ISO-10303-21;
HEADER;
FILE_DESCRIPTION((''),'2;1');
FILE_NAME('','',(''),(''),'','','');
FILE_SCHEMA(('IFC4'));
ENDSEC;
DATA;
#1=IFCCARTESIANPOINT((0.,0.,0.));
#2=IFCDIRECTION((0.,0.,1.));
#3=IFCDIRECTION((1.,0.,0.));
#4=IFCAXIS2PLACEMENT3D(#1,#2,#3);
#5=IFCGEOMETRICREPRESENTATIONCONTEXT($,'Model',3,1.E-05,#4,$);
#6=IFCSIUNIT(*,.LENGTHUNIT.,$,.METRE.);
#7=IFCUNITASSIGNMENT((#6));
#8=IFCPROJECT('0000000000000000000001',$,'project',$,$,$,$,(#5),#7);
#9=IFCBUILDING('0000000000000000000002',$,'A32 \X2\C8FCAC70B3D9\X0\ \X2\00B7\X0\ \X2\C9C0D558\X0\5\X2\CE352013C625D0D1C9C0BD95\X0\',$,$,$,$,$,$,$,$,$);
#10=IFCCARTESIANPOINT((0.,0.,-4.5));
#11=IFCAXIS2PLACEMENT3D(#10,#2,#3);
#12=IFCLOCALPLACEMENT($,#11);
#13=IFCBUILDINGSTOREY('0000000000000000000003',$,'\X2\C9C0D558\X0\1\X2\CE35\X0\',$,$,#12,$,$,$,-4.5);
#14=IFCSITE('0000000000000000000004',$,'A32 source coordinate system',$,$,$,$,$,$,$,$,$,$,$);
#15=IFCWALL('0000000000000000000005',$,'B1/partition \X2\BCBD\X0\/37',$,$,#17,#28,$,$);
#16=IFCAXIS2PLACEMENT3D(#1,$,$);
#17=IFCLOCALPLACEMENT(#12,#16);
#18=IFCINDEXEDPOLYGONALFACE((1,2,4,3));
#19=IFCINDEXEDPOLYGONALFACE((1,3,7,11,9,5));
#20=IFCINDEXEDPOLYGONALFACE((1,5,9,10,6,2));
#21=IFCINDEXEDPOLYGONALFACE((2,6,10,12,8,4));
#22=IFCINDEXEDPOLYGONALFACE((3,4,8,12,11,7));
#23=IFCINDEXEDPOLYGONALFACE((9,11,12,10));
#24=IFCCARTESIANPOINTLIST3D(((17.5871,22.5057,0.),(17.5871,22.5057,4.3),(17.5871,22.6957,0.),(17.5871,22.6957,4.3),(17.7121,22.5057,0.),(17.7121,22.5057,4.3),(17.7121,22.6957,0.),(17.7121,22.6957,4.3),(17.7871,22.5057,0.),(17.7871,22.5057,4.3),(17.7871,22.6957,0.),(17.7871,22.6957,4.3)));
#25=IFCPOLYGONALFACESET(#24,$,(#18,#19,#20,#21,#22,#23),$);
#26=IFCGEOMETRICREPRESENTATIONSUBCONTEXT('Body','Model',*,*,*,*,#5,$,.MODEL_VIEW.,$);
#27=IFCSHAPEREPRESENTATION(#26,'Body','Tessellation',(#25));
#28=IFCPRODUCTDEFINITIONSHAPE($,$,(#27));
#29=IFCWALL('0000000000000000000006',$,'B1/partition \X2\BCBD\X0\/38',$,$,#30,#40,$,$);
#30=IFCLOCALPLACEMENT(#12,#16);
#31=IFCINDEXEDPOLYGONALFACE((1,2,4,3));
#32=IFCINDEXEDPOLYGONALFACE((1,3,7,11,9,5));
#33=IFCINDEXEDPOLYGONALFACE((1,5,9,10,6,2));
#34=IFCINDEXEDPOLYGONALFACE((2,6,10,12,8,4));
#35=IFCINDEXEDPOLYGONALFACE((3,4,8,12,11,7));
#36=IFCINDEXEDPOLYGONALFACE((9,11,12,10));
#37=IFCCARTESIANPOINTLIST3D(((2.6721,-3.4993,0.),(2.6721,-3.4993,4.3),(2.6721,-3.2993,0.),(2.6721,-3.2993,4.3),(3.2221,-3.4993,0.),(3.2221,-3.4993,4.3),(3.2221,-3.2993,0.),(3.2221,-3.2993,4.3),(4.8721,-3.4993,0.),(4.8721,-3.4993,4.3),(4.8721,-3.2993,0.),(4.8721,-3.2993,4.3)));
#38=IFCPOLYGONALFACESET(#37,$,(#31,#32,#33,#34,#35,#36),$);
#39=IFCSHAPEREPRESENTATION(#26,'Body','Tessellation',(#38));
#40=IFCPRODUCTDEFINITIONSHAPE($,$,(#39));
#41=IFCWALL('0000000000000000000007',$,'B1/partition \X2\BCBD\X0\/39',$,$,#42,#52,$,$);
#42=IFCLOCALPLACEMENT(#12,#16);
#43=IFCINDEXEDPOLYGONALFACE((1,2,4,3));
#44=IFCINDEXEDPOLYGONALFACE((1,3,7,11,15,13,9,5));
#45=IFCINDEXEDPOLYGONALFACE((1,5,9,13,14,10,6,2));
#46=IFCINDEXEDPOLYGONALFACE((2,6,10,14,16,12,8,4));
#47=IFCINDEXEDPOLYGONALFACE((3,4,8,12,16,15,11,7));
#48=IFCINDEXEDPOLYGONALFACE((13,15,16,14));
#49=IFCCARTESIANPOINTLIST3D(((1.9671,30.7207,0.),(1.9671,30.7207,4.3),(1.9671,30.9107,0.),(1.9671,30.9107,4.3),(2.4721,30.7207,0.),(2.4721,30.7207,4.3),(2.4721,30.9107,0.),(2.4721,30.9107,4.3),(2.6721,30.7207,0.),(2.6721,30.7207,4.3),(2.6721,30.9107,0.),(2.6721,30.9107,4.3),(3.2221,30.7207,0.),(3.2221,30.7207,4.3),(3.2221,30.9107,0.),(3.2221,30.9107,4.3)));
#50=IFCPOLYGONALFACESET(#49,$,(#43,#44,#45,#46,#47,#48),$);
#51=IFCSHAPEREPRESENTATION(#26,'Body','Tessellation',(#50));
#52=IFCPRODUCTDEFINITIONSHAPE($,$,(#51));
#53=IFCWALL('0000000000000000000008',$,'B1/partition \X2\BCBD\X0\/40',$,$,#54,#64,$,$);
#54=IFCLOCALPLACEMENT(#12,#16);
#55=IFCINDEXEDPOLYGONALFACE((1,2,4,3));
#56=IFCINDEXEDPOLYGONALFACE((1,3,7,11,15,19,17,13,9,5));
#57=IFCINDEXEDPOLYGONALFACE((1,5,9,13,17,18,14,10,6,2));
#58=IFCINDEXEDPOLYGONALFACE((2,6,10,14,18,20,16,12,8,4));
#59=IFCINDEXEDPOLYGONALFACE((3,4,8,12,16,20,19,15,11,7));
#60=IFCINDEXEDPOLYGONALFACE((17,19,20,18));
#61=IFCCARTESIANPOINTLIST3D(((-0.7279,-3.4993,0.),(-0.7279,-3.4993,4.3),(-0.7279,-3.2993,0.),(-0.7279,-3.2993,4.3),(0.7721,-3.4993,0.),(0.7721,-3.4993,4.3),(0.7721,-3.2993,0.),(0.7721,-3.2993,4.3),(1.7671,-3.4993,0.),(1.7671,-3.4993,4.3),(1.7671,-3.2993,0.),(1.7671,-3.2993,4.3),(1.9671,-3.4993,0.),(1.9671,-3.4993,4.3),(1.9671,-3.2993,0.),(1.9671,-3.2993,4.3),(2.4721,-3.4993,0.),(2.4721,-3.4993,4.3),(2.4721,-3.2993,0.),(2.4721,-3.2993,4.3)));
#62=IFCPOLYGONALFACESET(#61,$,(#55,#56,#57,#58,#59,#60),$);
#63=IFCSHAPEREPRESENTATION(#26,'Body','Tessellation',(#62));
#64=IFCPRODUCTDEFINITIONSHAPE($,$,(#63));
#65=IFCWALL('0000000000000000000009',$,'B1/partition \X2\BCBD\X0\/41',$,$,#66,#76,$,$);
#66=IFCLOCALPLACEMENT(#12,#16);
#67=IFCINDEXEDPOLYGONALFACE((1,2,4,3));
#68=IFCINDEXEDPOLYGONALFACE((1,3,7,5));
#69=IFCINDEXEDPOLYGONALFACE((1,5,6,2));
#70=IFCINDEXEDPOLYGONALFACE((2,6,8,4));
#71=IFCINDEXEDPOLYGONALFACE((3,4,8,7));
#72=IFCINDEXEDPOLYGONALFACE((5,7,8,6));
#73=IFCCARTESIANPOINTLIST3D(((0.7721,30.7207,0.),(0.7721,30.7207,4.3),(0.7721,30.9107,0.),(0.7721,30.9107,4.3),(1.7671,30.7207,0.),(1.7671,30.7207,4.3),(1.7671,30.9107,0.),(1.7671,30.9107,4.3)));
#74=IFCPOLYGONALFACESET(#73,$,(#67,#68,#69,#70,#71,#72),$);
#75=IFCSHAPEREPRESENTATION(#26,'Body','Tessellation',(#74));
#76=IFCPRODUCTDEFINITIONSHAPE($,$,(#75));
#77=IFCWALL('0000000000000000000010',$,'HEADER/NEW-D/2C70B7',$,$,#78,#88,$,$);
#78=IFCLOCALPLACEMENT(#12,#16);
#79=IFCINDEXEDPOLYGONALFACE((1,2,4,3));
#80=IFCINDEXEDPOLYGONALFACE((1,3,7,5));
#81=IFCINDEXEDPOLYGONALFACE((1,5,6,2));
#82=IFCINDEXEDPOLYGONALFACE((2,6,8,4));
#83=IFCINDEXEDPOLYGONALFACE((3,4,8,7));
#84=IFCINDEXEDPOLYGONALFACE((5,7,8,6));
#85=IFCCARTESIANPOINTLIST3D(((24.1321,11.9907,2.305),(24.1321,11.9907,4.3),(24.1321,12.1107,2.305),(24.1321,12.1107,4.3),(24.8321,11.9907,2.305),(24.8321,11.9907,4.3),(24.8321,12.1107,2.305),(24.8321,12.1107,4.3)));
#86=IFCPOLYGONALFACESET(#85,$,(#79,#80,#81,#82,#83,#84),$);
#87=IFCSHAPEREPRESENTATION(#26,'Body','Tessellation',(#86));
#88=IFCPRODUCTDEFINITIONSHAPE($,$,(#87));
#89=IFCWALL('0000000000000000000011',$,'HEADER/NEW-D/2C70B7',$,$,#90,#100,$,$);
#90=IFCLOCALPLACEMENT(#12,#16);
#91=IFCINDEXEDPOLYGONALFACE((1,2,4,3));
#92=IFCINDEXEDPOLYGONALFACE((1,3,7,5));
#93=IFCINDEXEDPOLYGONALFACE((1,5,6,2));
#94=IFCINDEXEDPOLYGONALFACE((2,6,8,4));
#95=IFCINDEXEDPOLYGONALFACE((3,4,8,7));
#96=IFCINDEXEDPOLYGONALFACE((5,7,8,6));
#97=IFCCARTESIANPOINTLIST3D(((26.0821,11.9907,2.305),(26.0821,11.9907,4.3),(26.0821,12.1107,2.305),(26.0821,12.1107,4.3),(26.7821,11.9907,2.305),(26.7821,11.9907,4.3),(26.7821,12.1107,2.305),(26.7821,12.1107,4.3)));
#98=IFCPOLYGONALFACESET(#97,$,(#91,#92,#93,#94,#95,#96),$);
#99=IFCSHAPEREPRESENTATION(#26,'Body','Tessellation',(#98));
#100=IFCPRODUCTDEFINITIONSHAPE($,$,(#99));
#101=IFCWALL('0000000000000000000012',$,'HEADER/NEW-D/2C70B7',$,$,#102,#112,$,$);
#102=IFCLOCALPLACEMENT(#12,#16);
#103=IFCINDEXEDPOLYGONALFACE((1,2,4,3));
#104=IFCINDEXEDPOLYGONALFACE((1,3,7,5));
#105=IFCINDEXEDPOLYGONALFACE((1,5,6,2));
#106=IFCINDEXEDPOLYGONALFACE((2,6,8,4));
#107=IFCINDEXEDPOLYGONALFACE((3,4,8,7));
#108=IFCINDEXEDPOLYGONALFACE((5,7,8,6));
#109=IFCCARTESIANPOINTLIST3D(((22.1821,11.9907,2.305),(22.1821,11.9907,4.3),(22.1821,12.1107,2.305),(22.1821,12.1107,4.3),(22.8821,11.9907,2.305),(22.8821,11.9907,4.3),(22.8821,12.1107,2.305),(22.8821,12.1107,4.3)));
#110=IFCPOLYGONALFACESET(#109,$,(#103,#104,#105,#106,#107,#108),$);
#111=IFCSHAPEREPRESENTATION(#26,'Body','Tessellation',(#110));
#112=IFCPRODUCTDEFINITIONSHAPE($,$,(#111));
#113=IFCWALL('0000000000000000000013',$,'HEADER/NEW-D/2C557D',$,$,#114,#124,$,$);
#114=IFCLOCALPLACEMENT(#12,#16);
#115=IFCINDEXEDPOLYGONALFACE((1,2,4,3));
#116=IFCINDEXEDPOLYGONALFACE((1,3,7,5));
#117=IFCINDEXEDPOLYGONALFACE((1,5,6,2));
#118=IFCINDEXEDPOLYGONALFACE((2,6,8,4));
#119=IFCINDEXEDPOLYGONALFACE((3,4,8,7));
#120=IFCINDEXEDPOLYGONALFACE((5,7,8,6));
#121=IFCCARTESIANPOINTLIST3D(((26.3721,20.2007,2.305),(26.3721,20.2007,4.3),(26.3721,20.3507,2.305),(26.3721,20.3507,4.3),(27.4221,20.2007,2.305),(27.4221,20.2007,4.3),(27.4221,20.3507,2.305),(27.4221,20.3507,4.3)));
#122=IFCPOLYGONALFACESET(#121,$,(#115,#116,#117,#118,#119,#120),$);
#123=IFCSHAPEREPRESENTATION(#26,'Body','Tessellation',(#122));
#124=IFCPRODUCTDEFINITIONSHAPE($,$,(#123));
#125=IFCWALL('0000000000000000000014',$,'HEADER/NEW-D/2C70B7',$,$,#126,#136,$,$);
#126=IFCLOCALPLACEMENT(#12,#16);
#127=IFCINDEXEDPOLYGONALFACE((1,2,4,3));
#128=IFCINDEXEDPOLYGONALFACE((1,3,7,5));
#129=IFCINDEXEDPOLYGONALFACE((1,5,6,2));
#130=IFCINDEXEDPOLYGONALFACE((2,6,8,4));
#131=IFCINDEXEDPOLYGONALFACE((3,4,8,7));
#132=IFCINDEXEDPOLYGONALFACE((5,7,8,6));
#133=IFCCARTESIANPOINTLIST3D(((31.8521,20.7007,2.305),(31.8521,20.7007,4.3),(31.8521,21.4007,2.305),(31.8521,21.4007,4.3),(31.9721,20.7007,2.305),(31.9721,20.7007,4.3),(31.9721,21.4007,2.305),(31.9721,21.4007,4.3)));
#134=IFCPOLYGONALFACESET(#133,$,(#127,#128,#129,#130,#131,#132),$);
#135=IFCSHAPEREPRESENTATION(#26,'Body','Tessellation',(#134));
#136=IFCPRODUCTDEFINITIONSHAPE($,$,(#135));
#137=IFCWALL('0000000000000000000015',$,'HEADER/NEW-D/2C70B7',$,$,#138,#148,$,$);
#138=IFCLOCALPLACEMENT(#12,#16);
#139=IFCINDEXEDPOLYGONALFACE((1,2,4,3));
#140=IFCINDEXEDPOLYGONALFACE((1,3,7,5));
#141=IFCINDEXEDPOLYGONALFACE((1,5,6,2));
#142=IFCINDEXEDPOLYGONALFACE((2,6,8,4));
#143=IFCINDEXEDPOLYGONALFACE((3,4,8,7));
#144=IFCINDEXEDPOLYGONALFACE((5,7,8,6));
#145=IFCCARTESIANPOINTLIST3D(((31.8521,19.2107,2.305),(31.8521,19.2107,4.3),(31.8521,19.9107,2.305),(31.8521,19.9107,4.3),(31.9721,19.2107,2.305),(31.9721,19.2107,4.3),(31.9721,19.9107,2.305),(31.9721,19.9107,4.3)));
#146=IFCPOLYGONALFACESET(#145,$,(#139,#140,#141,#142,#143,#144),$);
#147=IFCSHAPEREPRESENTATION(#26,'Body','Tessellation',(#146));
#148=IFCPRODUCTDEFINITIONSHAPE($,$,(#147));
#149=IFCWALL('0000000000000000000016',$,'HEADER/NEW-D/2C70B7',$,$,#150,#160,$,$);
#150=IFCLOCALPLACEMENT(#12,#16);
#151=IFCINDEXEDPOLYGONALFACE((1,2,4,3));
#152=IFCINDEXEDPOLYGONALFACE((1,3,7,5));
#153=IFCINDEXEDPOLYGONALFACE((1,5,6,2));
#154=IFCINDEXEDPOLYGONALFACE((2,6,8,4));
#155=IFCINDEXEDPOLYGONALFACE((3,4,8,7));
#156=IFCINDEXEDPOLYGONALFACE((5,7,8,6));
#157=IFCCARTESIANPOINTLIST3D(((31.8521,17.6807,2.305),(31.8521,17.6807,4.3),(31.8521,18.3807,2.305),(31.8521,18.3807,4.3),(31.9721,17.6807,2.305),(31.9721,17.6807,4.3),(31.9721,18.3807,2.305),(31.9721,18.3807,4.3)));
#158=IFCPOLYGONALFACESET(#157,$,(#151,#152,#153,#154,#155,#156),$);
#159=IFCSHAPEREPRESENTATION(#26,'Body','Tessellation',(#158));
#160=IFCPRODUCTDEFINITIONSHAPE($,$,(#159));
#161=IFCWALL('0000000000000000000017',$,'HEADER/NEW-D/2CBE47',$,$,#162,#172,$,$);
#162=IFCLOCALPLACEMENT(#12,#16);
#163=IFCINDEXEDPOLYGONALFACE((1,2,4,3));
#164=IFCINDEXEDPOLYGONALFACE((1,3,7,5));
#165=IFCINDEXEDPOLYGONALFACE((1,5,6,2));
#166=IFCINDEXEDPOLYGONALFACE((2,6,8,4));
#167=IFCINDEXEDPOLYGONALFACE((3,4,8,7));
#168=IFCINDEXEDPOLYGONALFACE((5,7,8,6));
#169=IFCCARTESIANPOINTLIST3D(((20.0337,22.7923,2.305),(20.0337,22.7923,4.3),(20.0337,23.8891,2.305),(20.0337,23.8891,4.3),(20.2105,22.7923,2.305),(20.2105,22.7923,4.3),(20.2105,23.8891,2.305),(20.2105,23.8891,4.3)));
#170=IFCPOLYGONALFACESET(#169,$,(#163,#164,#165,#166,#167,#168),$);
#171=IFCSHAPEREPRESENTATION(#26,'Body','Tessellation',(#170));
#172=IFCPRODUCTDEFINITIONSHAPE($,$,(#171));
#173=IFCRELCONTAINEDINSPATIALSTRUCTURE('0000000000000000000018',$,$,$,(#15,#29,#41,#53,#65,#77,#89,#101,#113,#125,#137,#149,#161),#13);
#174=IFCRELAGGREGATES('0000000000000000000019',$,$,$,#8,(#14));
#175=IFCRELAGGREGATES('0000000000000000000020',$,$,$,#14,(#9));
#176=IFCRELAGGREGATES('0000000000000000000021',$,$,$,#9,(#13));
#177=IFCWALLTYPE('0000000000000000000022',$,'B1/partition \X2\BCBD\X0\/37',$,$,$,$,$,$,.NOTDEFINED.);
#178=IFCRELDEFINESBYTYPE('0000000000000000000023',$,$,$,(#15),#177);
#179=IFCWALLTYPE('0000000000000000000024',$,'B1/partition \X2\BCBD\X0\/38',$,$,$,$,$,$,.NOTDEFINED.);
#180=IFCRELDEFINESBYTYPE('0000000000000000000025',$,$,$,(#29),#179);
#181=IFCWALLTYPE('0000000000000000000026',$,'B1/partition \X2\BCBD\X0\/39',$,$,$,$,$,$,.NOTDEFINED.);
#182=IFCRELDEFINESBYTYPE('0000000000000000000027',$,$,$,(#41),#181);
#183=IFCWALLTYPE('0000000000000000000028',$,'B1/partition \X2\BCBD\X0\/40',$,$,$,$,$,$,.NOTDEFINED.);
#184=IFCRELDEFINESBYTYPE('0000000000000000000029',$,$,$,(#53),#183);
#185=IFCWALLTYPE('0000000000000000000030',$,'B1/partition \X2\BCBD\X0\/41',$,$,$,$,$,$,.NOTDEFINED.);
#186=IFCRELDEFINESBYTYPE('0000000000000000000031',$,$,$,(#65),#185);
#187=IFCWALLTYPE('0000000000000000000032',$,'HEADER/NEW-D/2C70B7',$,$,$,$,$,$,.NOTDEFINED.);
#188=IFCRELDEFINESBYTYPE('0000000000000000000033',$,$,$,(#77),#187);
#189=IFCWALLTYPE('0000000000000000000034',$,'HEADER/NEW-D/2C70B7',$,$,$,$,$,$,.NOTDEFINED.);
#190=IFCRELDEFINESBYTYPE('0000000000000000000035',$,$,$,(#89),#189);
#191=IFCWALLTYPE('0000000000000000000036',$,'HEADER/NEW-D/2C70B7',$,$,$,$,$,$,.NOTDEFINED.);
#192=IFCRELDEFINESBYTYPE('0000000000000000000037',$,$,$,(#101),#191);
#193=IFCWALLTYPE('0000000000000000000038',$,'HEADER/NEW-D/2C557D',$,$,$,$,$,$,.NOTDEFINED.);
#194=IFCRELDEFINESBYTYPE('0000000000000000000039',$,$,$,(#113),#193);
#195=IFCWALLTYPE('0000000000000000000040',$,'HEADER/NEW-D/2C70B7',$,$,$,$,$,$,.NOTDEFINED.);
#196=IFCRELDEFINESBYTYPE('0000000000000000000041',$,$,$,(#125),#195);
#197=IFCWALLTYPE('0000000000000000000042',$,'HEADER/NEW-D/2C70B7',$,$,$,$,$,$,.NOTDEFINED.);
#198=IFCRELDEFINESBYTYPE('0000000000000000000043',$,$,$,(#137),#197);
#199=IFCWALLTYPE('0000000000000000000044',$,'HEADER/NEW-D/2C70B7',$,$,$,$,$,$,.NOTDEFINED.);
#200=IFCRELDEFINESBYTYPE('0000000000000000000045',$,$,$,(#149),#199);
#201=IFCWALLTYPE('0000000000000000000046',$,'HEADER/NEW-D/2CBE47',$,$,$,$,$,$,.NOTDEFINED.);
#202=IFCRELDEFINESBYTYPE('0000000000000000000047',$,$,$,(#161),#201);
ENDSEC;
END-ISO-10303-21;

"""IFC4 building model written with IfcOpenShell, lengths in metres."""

from ifc_helpers import new_model, si_unit, frame, origin, origin_with_axes, place, context, subcontext, project, spatial, polyline, outline, extrude, source, transform, mapped, type_object, type_shapes, element, save


model = new_model("IFC4")

# Units and contexts
model_context = context("Model", 3, precision=1e-05, world=origin_with_axes())
body_context = subcontext(model_context, "Body", "Model", "MODEL_VIEW")
ifc_project = project(units=[si_unit("LENGTHUNIT", "METRE")], contexts=[model_context])

# Site, building, storey
site = spatial("IfcSite", under=ifc_project, Name="A32 source coordinate system")
building = spatial("IfcBuilding", under=site, Name="A32 주거동 · 지하5층–옥탑지붕")
storey_placement = place(None, frame((0.0, 0.0, -4.5), z_axis=(0.0, 0.0, 1.0), x_axis=(1.0, 0.0, 0.0)))
storey = spatial("IfcBuildingStorey", under=building, at=storey_placement, Name="지하1층", Elevation=-4.5)

# Walls
wall_type_1 = type_object("IfcWallType", Name="B1/partition 벽/37", PredefinedType="NOTDEFINED")
shared_shape_1 = source(origin(), body_context, "Body", "SweptSolid", [
    extrude(outline(polyline([(17.5871, 22.6957), (17.7121, 22.6957), (17.7871, 22.6957), (17.7871, 22.5057), (17.7121, 22.5057), (17.5871, 22.5057), (17.5871, 22.6957)])), origin(), (0.0, 0.0, 1.0), 4.3),
])
type_shapes(wall_type_1, [shared_shape_1])
wall_1_placement = place(storey_placement, origin_with_axes())
element("IfcWall", 1, at=wall_1_placement, inside=storey, type_object=wall_type_1, Name="B1/partition 벽/37", context=body_context, shape_type="MappedRepresentation", body=[
    mapped(shared_shape_1, transform((0.0, 0.0, 0.0), scale=1.0)),
])
wall_type_2 = type_object("IfcWallType", Name="B1/partition 벽/38", PredefinedType="NOTDEFINED")
shared_shape_2 = source(origin(), body_context, "Body", "SweptSolid", [
    extrude(outline(polyline([(2.6721, -3.2993), (3.2221, -3.2993), (4.8721, -3.2993), (4.8721, -3.4993), (3.2221, -3.4993), (2.6721, -3.4993), (2.6721, -3.2993)])), origin(), (0.0, 0.0, 1.0), 4.3),
])
type_shapes(wall_type_2, [shared_shape_2])
wall_2_placement = place(storey_placement, origin_with_axes())
element("IfcWall", 2, at=wall_2_placement, inside=storey, type_object=wall_type_2, Name="B1/partition 벽/38", context=body_context, shape_type="MappedRepresentation", body=[
    mapped(shared_shape_2, transform((0.0, 0.0, 0.0), scale=1.0)),
])
wall_type_3 = type_object("IfcWallType", Name="B1/partition 벽/39", PredefinedType="NOTDEFINED")
shared_shape_3 = source(origin(), body_context, "Body", "SweptSolid", [
    extrude(outline(polyline([(2.6721, 30.7207), (2.4721, 30.7207), (1.9671, 30.7207), (1.9671, 30.9107), (2.4721, 30.9107), (2.6721, 30.9107), (3.2221, 30.9107), (3.2221, 30.7207), (2.6721, 30.7207)])), origin(), (0.0, 0.0, 1.0), 4.3),
])
type_shapes(wall_type_3, [shared_shape_3])
wall_3_placement = place(storey_placement, origin_with_axes())
element("IfcWall", 3, at=wall_3_placement, inside=storey, type_object=wall_type_3, Name="B1/partition 벽/39", context=body_context, shape_type="MappedRepresentation", body=[
    mapped(shared_shape_3, transform((0.0, 0.0, 0.0), scale=1.0)),
])
wall_type_4 = type_object("IfcWallType", Name="B1/partition 벽/40", PredefinedType="NOTDEFINED")
shared_shape_4 = source(origin(), body_context, "Body", "SweptSolid", [
    extrude(outline(polyline([(2.4721, -3.4993), (1.9671, -3.4993), (1.7671, -3.4993), (0.7721, -3.4993), (-0.7279, -3.4993), (-0.7279, -3.2993), (0.7721, -3.2993), (1.7671, -3.2993), (1.9671, -3.2993), (2.4721, -3.2993), (2.4721, -3.4993)])), origin(), (0.0, 0.0, 1.0), 4.3),
])
type_shapes(wall_type_4, [shared_shape_4])
wall_4_placement = place(storey_placement, origin_with_axes())
element("IfcWall", 4, at=wall_4_placement, inside=storey, type_object=wall_type_4, Name="B1/partition 벽/40", context=body_context, shape_type="MappedRepresentation", body=[
    mapped(shared_shape_4, transform((0.0, 0.0, 0.0), scale=1.0)),
])
wall_type_5 = type_object("IfcWallType", Name="B1/partition 벽/41", PredefinedType="NOTDEFINED")
shared_shape_5 = source(origin(), body_context, "Body", "SweptSolid", [
    extrude(outline(polyline([(1.7671, 30.7207), (0.7721, 30.7207), (0.7721, 30.9107), (1.7671, 30.9107), (1.7671, 30.7207)])), origin(), (0.0, 0.0, 1.0), 4.3),
])
type_shapes(wall_type_5, [shared_shape_5])
wall_5_placement = place(storey_placement, origin_with_axes())
element("IfcWall", 5, at=wall_5_placement, inside=storey, type_object=wall_type_5, Name="B1/partition 벽/41", context=body_context, shape_type="MappedRepresentation", body=[
    mapped(shared_shape_5, transform((0.0, 0.0, 0.0), scale=1.0)),
])
wall_type_6 = type_object("IfcWallType", Name="HEADER/NEW-D/2C70B7", PredefinedType="NOTDEFINED")
shared_shape_6 = source(origin(), body_context, "Body", "SweptSolid", [
    extrude(outline(polyline([(24.1321, 11.9907), (24.1321, 12.1107), (24.8321, 12.1107), (24.8321, 11.9907), (24.1321, 11.9907)])), frame((0.0, 0.0, 2.305)), (0.0, 0.0, 1.0), 1.995),
])
type_shapes(wall_type_6, [shared_shape_6])
wall_6_placement = place(storey_placement, origin_with_axes())
element("IfcWall", 6, at=wall_6_placement, inside=storey, type_object=wall_type_6, Name="HEADER/NEW-D/2C70B7", context=body_context, shape_type="MappedRepresentation", body=[
    mapped(shared_shape_6, transform((0.0, 0.0, 0.0), scale=1.0)),
])
wall_type_7 = type_object("IfcWallType", Name="HEADER/NEW-D/2C70B7", PredefinedType="NOTDEFINED")
shared_shape_7 = source(origin(), body_context, "Body", "SweptSolid", [
    extrude(outline(polyline([(26.0821, 11.9907), (26.0821, 12.1107), (26.7821, 12.1107), (26.7821, 11.9907), (26.0821, 11.9907)])), frame((0.0, 0.0, 2.305)), (0.0, 0.0, 1.0), 1.995),
])
type_shapes(wall_type_7, [shared_shape_7])
wall_7_placement = place(storey_placement, origin_with_axes())
element("IfcWall", 7, at=wall_7_placement, inside=storey, type_object=wall_type_7, Name="HEADER/NEW-D/2C70B7", context=body_context, shape_type="MappedRepresentation", body=[
    mapped(shared_shape_7, transform((0.0, 0.0, 0.0), scale=1.0)),
])
wall_type_8 = type_object("IfcWallType", Name="HEADER/NEW-D/2C70B7", PredefinedType="NOTDEFINED")
shared_shape_8 = source(origin(), body_context, "Body", "SweptSolid", [
    extrude(outline(polyline([(22.1821, 11.9907), (22.1821, 12.1107), (22.8821, 12.1107), (22.8821, 11.9907), (22.1821, 11.9907)])), frame((0.0, 0.0, 2.305)), (0.0, 0.0, 1.0), 1.995),
])
type_shapes(wall_type_8, [shared_shape_8])
wall_8_placement = place(storey_placement, origin_with_axes())
element("IfcWall", 8, at=wall_8_placement, inside=storey, type_object=wall_type_8, Name="HEADER/NEW-D/2C70B7", context=body_context, shape_type="MappedRepresentation", body=[
    mapped(shared_shape_8, transform((0.0, 0.0, 0.0), scale=1.0)),
])
wall_type_9 = type_object("IfcWallType", Name="HEADER/NEW-D/2C557D", PredefinedType="NOTDEFINED")
shared_shape_9 = source(origin(), body_context, "Body", "SweptSolid", [
    extrude(outline(polyline([(26.3721, 20.2007), (26.3721, 20.3507), (27.4221, 20.3507), (27.4221, 20.2007), (26.3721, 20.2007)])), frame((0.0, 0.0, 2.305)), (0.0, 0.0, 1.0), 1.995),
])
type_shapes(wall_type_9, [shared_shape_9])
wall_9_placement = place(storey_placement, origin_with_axes())
element("IfcWall", 9, at=wall_9_placement, inside=storey, type_object=wall_type_9, Name="HEADER/NEW-D/2C557D", context=body_context, shape_type="MappedRepresentation", body=[
    mapped(shared_shape_9, transform((0.0, 0.0, 0.0), scale=1.0)),
])
wall_type_10 = type_object("IfcWallType", Name="HEADER/NEW-D/2C70B7", PredefinedType="NOTDEFINED")
shared_shape_10 = source(origin(), body_context, "Body", "SweptSolid", [
    extrude(outline(polyline([(31.8521, 20.7007), (31.8521, 21.4007), (31.9721, 21.4007), (31.9721, 20.7007), (31.8521, 20.7007)])), frame((0.0, 0.0, 2.305)), (0.0, 0.0, 1.0), 1.995),
])
type_shapes(wall_type_10, [shared_shape_10])
wall_10_placement = place(storey_placement, origin_with_axes())
element("IfcWall", 10, at=wall_10_placement, inside=storey, type_object=wall_type_10, Name="HEADER/NEW-D/2C70B7", context=body_context, shape_type="MappedRepresentation", body=[
    mapped(shared_shape_10, transform((0.0, 0.0, 0.0), scale=1.0)),
])
wall_type_11 = type_object("IfcWallType", Name="HEADER/NEW-D/2C70B7", PredefinedType="NOTDEFINED")
shared_shape_11 = source(origin(), body_context, "Body", "SweptSolid", [
    extrude(outline(polyline([(31.8521, 19.2107), (31.8521, 19.9107), (31.9721, 19.9107), (31.9721, 19.2107), (31.8521, 19.2107)])), frame((0.0, 0.0, 2.305)), (0.0, 0.0, 1.0), 1.995),
])
type_shapes(wall_type_11, [shared_shape_11])
wall_11_placement = place(storey_placement, origin_with_axes())
element("IfcWall", 11, at=wall_11_placement, inside=storey, type_object=wall_type_11, Name="HEADER/NEW-D/2C70B7", context=body_context, shape_type="MappedRepresentation", body=[
    mapped(shared_shape_11, transform((0.0, 0.0, 0.0), scale=1.0)),
])
wall_type_12 = type_object("IfcWallType", Name="HEADER/NEW-D/2C70B7", PredefinedType="NOTDEFINED")
shared_shape_12 = source(origin(), body_context, "Body", "SweptSolid", [
    extrude(outline(polyline([(31.8521, 17.6807), (31.8521, 18.3807), (31.9721, 18.3807), (31.9721, 17.6807), (31.8521, 17.6807)])), frame((0.0, 0.0, 2.305)), (0.0, 0.0, 1.0), 1.995),
])
type_shapes(wall_type_12, [shared_shape_12])
wall_12_placement = place(storey_placement, origin_with_axes())
element("IfcWall", 12, at=wall_12_placement, inside=storey, type_object=wall_type_12, Name="HEADER/NEW-D/2C70B7", context=body_context, shape_type="MappedRepresentation", body=[
    mapped(shared_shape_12, transform((0.0, 0.0, 0.0), scale=1.0)),
])
wall_type_13 = type_object("IfcWallType", Name="HEADER/NEW-D/2CBE47", PredefinedType="NOTDEFINED")
shared_shape_13 = source(origin(), body_context, "Body", "SweptSolid", [
    extrude(outline(polyline([(20.0337, 22.7923), (20.0337, 23.8891), (20.2105, 23.8891), (20.2105, 22.7923), (20.0337, 22.7923)])), frame((0.0, 0.0, 2.305)), (0.0, 0.0, 1.0), 1.995),
])
type_shapes(wall_type_13, [shared_shape_13])
wall_13_placement = place(storey_placement, origin_with_axes())
element("IfcWall", 13, at=wall_13_placement, inside=storey, type_object=wall_type_13, Name="HEADER/NEW-D/2CBE47", context=body_context, shape_type="MappedRepresentation", body=[
    mapped(shared_shape_13, transform((0.0, 0.0, 0.0), scale=1.0)),
])

save(model, "model.ifc")
